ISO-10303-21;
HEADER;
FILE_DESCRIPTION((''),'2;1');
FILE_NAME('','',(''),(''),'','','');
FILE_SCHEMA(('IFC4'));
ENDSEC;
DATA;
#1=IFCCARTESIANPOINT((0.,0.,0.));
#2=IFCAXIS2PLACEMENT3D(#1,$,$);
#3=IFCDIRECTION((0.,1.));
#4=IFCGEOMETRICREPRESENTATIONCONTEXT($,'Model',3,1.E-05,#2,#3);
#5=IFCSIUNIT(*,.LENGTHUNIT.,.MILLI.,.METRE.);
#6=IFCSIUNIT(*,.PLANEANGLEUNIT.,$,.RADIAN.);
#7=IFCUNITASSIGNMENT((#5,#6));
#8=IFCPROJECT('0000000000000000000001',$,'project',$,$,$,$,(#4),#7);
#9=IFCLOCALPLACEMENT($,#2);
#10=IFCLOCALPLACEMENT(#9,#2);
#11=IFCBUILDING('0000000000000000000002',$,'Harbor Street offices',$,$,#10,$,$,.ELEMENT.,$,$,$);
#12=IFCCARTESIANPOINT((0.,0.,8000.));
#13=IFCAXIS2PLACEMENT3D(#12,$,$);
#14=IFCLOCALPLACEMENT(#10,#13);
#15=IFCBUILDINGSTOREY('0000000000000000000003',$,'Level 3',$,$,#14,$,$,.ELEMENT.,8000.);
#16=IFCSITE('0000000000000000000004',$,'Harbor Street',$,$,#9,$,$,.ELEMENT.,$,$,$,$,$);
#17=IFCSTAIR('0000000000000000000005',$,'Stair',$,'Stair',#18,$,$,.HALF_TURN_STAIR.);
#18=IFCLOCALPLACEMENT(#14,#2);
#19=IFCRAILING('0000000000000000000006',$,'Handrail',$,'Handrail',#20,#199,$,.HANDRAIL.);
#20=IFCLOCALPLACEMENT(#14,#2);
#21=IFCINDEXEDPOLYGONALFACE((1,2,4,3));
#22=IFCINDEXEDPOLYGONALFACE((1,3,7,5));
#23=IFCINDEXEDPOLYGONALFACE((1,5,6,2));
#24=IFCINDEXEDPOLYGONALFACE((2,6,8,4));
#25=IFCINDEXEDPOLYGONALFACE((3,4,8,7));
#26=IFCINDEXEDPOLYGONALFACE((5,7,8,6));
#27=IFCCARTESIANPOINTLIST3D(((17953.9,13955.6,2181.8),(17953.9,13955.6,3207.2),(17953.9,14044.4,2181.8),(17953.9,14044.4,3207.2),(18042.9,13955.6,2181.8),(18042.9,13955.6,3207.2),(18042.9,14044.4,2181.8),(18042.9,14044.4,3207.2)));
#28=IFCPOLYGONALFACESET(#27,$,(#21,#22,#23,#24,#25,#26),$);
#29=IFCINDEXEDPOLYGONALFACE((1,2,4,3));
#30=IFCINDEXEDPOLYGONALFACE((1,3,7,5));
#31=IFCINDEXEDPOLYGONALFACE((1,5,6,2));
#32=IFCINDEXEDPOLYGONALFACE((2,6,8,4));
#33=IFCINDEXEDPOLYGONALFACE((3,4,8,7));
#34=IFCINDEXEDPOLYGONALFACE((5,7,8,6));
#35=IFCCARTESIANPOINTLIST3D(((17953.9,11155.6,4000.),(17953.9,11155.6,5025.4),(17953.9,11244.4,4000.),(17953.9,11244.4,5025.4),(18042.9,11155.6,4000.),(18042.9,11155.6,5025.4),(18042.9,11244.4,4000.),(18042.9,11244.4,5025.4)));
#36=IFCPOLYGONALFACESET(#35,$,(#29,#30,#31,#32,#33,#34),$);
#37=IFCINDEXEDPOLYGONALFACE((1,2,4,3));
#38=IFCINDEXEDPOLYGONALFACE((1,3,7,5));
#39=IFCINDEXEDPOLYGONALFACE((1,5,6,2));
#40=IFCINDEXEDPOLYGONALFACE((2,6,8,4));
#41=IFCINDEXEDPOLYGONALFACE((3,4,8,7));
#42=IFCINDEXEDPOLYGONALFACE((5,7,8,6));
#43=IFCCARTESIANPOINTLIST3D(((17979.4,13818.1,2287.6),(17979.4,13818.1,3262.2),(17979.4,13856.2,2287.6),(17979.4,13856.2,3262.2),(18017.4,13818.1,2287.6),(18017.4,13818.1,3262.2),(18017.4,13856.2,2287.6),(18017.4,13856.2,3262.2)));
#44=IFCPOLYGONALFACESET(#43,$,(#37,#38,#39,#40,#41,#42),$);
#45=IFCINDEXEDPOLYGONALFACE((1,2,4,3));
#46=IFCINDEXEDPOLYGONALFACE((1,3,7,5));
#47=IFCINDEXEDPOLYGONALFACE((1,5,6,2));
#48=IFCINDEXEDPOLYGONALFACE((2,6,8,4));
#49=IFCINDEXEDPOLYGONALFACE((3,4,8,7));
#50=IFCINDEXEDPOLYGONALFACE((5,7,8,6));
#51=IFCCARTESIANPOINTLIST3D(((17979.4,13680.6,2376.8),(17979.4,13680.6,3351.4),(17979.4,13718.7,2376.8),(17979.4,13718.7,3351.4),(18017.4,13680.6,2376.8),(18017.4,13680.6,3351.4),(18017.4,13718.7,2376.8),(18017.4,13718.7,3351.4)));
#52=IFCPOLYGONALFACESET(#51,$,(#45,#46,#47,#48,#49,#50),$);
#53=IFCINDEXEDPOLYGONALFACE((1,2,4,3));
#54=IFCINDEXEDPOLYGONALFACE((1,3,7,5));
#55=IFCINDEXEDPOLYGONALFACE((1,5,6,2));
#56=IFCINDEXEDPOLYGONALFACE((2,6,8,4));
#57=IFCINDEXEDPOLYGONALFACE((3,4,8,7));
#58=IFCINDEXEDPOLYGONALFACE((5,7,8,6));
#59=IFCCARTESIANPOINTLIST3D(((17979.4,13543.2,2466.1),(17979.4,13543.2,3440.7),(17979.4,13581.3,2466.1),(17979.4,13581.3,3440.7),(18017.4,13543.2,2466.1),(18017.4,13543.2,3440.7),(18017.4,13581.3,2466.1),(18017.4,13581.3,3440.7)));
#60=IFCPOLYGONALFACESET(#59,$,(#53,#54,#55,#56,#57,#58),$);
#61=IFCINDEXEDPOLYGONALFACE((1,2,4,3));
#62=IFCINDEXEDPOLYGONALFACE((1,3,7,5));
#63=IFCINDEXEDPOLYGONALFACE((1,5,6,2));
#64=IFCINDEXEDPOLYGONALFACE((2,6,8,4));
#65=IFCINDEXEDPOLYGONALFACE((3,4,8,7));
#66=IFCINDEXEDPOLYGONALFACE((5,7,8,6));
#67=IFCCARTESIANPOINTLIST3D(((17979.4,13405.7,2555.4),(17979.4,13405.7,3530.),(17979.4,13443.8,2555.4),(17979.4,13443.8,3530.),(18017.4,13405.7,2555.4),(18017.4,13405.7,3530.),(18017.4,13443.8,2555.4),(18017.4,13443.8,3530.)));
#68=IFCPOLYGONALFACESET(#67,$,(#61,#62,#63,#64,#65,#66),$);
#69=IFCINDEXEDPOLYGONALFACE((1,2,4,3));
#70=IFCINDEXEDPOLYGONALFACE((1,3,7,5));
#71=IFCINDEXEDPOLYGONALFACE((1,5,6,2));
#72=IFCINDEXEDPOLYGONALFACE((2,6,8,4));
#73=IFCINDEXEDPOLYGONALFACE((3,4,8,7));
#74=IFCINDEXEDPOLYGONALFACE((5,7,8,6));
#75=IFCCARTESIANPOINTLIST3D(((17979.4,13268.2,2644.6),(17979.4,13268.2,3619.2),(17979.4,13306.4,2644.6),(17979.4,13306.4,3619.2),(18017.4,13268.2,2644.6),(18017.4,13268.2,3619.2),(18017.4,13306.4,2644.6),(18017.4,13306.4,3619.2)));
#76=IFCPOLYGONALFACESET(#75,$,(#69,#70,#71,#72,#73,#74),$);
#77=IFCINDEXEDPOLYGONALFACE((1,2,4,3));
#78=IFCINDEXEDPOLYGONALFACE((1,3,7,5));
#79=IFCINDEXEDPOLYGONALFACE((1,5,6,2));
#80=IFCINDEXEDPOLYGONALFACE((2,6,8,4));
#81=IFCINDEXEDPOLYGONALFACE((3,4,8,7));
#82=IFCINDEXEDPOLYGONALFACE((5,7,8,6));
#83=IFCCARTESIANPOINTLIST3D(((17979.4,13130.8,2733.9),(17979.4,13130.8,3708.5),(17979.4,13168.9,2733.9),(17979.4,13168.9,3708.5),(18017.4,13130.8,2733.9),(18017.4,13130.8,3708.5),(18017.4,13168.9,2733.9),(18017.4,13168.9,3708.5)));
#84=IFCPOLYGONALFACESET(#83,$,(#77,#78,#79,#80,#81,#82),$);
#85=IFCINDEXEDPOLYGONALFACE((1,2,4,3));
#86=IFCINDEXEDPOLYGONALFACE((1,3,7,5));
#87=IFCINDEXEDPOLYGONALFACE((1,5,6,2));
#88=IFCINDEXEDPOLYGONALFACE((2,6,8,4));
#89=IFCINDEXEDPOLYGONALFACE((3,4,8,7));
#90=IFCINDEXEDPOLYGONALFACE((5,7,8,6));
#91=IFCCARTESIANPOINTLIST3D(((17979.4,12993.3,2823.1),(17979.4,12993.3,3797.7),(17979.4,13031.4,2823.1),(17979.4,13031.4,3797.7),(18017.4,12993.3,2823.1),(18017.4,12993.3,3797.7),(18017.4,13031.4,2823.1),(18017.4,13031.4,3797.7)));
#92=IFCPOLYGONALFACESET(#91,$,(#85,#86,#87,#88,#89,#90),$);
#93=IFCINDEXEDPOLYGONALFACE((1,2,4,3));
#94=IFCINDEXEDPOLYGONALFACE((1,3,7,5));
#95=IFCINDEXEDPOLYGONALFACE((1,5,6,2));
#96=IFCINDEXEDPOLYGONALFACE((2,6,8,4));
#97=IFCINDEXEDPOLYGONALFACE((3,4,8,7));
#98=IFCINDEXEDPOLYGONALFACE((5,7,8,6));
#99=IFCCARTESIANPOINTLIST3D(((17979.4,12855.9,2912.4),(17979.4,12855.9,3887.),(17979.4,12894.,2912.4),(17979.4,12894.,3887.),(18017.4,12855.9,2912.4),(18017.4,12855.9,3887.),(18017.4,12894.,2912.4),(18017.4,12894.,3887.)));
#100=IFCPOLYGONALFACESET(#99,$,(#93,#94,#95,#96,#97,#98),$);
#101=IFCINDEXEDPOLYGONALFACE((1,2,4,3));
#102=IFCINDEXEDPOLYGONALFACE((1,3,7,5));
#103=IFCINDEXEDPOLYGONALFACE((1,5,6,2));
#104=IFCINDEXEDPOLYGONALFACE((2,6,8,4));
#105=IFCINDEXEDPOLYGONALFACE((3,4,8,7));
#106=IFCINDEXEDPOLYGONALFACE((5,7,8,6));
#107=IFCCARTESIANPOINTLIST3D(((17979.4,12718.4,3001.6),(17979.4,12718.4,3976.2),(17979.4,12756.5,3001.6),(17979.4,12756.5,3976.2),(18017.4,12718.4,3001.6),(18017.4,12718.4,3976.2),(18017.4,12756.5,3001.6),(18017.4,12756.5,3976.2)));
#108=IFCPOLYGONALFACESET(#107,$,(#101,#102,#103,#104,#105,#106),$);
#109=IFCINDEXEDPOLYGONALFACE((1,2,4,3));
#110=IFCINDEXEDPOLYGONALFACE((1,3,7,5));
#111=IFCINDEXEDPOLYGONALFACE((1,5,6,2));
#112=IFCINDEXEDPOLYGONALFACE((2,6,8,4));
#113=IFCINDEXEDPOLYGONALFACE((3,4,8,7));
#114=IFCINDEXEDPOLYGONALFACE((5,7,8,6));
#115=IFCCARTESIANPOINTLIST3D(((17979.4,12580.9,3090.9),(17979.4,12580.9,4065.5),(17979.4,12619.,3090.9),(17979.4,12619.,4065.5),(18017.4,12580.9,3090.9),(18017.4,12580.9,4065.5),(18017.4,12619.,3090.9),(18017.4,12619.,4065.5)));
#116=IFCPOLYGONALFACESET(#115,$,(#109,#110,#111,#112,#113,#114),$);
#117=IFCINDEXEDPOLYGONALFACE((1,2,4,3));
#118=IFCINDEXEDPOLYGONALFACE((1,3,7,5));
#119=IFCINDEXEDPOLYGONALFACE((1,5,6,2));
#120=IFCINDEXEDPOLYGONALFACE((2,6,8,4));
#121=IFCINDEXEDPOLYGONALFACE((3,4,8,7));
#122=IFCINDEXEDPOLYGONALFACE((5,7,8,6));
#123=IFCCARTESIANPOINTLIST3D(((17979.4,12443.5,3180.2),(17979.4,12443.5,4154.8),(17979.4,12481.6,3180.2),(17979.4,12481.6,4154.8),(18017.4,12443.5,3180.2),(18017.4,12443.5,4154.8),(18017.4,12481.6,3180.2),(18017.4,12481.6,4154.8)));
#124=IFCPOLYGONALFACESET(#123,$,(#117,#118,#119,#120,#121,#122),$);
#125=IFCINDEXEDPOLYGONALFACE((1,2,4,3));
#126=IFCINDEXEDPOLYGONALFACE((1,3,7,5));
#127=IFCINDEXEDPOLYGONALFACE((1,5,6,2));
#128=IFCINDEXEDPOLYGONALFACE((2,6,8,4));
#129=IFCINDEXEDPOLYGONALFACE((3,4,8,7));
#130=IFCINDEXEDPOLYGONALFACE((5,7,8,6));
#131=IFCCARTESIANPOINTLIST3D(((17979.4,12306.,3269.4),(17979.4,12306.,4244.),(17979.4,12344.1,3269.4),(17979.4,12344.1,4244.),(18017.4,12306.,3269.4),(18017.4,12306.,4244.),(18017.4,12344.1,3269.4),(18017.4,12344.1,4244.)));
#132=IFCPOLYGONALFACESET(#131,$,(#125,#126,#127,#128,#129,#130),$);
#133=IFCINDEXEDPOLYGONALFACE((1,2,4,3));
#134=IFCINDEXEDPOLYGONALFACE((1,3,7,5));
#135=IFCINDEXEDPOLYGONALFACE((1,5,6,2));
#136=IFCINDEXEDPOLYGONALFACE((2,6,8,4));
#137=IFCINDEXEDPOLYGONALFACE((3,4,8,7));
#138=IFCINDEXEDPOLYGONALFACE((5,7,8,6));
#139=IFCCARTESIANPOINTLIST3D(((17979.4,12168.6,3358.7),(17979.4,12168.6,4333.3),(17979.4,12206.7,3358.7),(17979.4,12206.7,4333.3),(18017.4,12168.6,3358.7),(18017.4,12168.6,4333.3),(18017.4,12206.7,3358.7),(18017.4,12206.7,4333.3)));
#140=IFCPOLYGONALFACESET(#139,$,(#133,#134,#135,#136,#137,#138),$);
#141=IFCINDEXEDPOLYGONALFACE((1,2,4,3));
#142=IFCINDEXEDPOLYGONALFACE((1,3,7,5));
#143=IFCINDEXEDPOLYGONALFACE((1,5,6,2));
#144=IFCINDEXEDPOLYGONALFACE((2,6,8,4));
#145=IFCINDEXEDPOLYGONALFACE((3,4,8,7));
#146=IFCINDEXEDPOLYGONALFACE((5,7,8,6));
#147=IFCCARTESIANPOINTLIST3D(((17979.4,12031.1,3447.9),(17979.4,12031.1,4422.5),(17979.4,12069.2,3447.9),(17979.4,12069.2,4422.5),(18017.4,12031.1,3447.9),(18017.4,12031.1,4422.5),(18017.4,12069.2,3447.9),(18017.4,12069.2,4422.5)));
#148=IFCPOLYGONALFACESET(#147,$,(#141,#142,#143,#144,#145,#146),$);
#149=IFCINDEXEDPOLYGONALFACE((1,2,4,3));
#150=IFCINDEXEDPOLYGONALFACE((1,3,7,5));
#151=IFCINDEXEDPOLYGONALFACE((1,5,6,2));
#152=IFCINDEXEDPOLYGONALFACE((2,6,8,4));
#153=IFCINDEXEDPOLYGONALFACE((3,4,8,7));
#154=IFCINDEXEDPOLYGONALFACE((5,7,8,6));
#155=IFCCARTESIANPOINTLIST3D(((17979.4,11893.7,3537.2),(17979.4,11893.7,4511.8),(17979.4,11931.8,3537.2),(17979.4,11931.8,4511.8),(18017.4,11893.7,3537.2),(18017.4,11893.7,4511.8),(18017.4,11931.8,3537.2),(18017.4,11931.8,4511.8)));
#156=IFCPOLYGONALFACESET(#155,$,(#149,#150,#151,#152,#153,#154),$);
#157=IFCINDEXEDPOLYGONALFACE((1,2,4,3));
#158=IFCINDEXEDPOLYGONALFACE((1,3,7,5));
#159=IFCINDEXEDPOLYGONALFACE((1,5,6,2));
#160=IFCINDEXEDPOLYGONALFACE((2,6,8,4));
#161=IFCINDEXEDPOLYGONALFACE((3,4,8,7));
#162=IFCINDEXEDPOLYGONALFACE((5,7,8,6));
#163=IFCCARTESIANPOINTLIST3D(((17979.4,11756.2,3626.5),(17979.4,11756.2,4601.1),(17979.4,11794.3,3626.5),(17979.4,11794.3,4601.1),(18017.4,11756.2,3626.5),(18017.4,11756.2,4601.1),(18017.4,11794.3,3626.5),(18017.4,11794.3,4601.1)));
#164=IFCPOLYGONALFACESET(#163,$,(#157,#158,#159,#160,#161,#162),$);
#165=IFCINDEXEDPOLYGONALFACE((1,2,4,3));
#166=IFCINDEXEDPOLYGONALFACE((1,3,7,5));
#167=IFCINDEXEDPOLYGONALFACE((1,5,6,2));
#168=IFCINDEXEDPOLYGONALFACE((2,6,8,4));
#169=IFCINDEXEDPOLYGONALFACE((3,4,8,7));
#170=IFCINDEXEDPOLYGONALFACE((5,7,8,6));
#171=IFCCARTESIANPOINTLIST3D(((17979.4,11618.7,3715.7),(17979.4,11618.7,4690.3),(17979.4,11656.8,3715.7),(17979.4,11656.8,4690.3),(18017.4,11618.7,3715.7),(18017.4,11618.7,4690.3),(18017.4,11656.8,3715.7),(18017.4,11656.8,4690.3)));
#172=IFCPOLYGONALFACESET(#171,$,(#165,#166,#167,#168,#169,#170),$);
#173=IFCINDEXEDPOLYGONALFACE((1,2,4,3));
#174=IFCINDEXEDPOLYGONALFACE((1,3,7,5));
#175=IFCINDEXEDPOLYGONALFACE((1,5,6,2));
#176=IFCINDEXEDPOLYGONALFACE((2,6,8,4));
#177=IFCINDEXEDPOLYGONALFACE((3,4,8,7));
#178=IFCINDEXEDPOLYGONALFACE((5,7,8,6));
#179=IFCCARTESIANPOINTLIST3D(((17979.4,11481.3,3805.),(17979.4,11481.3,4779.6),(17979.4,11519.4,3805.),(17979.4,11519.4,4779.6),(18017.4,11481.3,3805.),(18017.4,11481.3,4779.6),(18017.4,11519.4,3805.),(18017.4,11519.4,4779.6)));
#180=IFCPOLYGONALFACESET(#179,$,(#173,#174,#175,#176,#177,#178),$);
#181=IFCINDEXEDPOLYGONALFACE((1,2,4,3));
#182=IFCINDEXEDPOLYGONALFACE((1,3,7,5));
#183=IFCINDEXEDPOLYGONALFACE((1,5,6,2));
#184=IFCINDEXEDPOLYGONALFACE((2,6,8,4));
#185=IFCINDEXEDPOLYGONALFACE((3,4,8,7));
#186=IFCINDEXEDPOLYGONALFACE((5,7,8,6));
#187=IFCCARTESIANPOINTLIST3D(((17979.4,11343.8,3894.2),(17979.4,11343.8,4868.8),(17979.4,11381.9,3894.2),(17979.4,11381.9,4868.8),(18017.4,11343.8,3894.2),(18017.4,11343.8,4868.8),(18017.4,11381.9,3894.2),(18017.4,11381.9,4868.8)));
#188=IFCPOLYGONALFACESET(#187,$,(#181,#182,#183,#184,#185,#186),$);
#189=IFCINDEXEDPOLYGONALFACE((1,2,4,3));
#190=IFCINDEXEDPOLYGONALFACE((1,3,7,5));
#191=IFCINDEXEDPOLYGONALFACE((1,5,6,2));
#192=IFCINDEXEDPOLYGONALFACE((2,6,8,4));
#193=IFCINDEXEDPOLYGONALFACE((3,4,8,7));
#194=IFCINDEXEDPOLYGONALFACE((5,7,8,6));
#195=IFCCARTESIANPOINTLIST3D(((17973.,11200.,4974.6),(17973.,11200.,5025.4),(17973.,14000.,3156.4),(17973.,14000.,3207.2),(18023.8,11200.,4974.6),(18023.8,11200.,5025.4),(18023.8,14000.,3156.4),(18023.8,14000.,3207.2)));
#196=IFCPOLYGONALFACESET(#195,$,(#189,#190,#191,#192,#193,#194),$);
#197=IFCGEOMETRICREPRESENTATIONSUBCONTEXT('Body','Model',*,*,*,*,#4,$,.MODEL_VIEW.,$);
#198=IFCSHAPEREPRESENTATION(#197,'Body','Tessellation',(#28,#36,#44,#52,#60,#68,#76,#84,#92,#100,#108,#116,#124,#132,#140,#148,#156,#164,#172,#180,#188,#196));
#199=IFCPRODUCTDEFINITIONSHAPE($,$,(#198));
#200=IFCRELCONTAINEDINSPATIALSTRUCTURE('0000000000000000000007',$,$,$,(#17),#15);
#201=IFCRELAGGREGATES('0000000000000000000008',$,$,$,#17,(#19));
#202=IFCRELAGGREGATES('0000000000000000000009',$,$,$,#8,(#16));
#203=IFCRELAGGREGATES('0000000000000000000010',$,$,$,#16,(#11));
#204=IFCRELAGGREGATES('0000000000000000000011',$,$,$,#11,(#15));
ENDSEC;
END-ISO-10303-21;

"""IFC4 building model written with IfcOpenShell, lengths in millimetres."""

from ifc_helpers import new_model, si_unit, direction, frame, origin, origin_with_axes, place, context, subcontext, project, spatial, polyline, outline, extrude, element, aggregate, save


model = new_model("IFC4")

# Units and contexts
model_context = context("Model", 3, precision=1e-05, world=origin(), true_north=direction((0.0, 1.0)))
body_context = subcontext(model_context, "Body", "Model", "MODEL_VIEW")
ifc_project = project(units=[si_unit("LENGTHUNIT", "METRE", prefix="MILLI"), si_unit("PLANEANGLEUNIT", "RADIAN")], contexts=[model_context])

# Site, building, storey
site_placement = place(None, origin())
site = spatial("IfcSite", under=ifc_project, at=site_placement, Name="Harbor Street", CompositionType="ELEMENT")
building_placement = place(site_placement, origin())
building = spatial("IfcBuilding", under=site, at=building_placement, Name="Harbor Street offices", CompositionType="ELEMENT")
storey_placement = place(building_placement, frame((0.0, 0.0, 8000.0)))
storey = spatial("IfcBuildingStorey", under=building, at=storey_placement, Name="Level 3", CompositionType="ELEMENT", Elevation=8000.0)

# Stair
stair_placement = place(storey_placement, origin_with_axes())
stair = element("IfcStair", 1, at=stair_placement, inside=storey, Name="Stair", ObjectType="Stair", PredefinedType="HALF_TURN_STAIR")

# Railing
railing_1_placement = place(storey_placement, origin_with_axes())
railing_1 = element("IfcRailing", 2, at=railing_1_placement, Name="Handrail", ObjectType="Handrail", PredefinedType="HANDRAIL", context=body_context, shape_type="SweptSolid", body=[
    extrude(outline(polyline([(-44.5, -44.5), (44.5, -44.5), (44.5, 44.5), (-44.5, 44.5), (-44.5, -44.5)])), frame((17998.4, 14000.0, 2181.8), z_axis=(0.0, 0.0, 1.0), x_axis=(1.0, 0.0, 0.0)), (0.0, 0.0, 1.0), 1025.4),
    extrude(outline(polyline([(-44.5, -44.5), (44.5, -44.5), (44.5, 44.5), (-44.5, 44.5), (-44.5, -44.5)])), frame((17998.4, 11200.0, 4000.0), z_axis=(0.0, 0.0, 1.0), x_axis=(1.0, 0.0, 0.0)), (0.0, 0.0, 1.0), 1025.4),
    extrude(outline(polyline([(-19.1, -19.1), (19.1, -19.1), (19.1, 19.1), (-19.1, 19.1), (-19.1, -19.1)])), frame((17998.4, 13837.1, 2287.6), z_axis=(0.0, 0.0, 1.0), x_axis=(1.0, 0.0, 0.0)), (0.0, 0.0, 1.0), 974.6),
    extrude(outline(polyline([(-19.1, -19.1), (19.1, -19.1), (19.1, 19.1), (-19.1, 19.1), (-19.1, -19.1)])), frame((17998.4, 13699.7, 2376.8), z_axis=(0.0, 0.0, 1.0), x_axis=(1.0, 0.0, 0.0)), (0.0, 0.0, 1.0), 974.6),
    extrude(outline(polyline([(-19.1, -19.1), (19.1, -19.1), (19.1, 19.1), (-19.1, 19.1), (-19.1, -19.1)])), frame((17998.4, 13562.2, 2466.1), z_axis=(0.0, 0.0, 1.0), x_axis=(1.0, 0.0, 0.0)), (0.0, 0.0, 1.0), 974.6),
    extrude(outline(polyline([(-19.1, -19.1), (19.1, -19.1), (19.1, 19.1), (-19.1, 19.1), (-19.1, -19.1)])), frame((17998.4, 13424.8, 2555.4), z_axis=(0.0, 0.0, 1.0), x_axis=(1.0, 0.0, 0.0)), (0.0, 0.0, 1.0), 974.6),
    extrude(outline(polyline([(-19.1, -19.1), (19.1, -19.1), (19.1, 19.1), (-19.1, 19.1), (-19.1, -19.1)])), frame((17998.4, 13287.3, 2644.6), z_axis=(0.0, 0.0, 1.0), x_axis=(1.0, 0.0, 0.0)), (0.0, 0.0, 1.0), 974.6),
    extrude(outline(polyline([(-19.1, -19.1), (19.1, -19.1), (19.1, 19.1), (-19.1, 19.1), (-19.1, -19.1)])), frame((17998.4, 13149.8, 2733.9), z_axis=(0.0, 0.0, 1.0), x_axis=(1.0, 0.0, 0.0)), (0.0, 0.0, 1.0), 974.6),
    extrude(outline(polyline([(-19.1, -19.1), (19.1, -19.1), (19.1, 19.1), (-19.1, 19.1), (-19.1, -19.1)])), frame((17998.4, 13012.4, 2823.1), z_axis=(0.0, 0.0, 1.0), x_axis=(1.0, 0.0, 0.0)), (0.0, 0.0, 1.0), 974.6),
    extrude(outline(polyline([(-19.1, -19.1), (19.1, -19.1), (19.1, 19.1), (-19.1, 19.1), (-19.1, -19.1)])), frame((17998.4, 12874.9, 2912.4), z_axis=(0.0, 0.0, 1.0), x_axis=(1.0, 0.0, 0.0)), (0.0, 0.0, 1.0), 974.6),
    extrude(outline(polyline([(-19.1, -19.1), (19.1, -19.1), (19.1, 19.1), (-19.1, 19.1), (-19.1, -19.1)])), frame((17998.4, 12737.5, 3001.6), z_axis=(0.0, 0.0, 1.0), x_axis=(1.0, 0.0, 0.0)), (0.0, 0.0, 1.0), 974.6),
    extrude(outline(polyline([(-19.1, -19.1), (19.1, -19.1), (19.1, 19.1), (-19.1, 19.1), (-19.1, -19.1)])), frame((17998.4, 12600.0, 3090.9), z_axis=(0.0, 0.0, 1.0), x_axis=(1.0, 0.0, 0.0)), (0.0, 0.0, 1.0), 974.6),
    extrude(outline(polyline([(-19.1, -19.1), (19.1, -19.1), (19.1, 19.1), (-19.1, 19.1), (-19.1, -19.1)])), frame((17998.4, 12462.5, 3180.2), z_axis=(0.0, 0.0, 1.0), x_axis=(1.0, 0.0, 0.0)), (0.0, 0.0, 1.0), 974.6),
    extrude(outline(polyline([(-19.1, -19.1), (19.1, -19.1), (19.1, 19.1), (-19.1, 19.1), (-19.1, -19.1)])), frame((17998.4, 12325.1, 3269.4), z_axis=(0.0, 0.0, 1.0), x_axis=(1.0, 0.0, 0.0)), (0.0, 0.0, 1.0), 974.6),
    extrude(outline(polyline([(-19.1, -19.1), (19.1, -19.1), (19.1, 19.1), (-19.1, 19.1), (-19.1, -19.1)])), frame((17998.4, 12187.6, 3358.7), z_axis=(0.0, 0.0, 1.0), x_axis=(1.0, 0.0, 0.0)), (0.0, 0.0, 1.0), 974.6),
    extrude(outline(polyline([(-19.1, -19.1), (19.1, -19.1), (19.1, 19.1), (-19.1, 19.1), (-19.1, -19.1)])), frame((17998.4, 12050.2, 3447.9), z_axis=(0.0, 0.0, 1.0), x_axis=(1.0, 0.0, 0.0)), (0.0, 0.0, 1.0), 974.6),
    extrude(outline(polyline([(-19.1, -19.1), (19.1, -19.1), (19.1, 19.1), (-19.1, 19.1), (-19.1, -19.1)])), frame((17998.4, 11912.7, 3537.2), z_axis=(0.0, 0.0, 1.0), x_axis=(1.0, 0.0, 0.0)), (0.0, 0.0, 1.0), 974.6),
    extrude(outline(polyline([(-19.1, -19.1), (19.1, -19.1), (19.1, 19.1), (-19.1, 19.1), (-19.1, -19.1)])), frame((17998.4, 11775.2, 3626.5), z_axis=(0.0, 0.0, 1.0), x_axis=(1.0, 0.0, 0.0)), (0.0, 0.0, 1.0), 974.6),
    extrude(outline(polyline([(-19.1, -19.1), (19.1, -19.1), (19.1, 19.1), (-19.1, 19.1), (-19.1, -19.1)])), frame((17998.4, 11637.8, 3715.7), z_axis=(0.0, 0.0, 1.0), x_axis=(1.0, 0.0, 0.0)), (0.0, 0.0, 1.0), 974.6),
    extrude(outline(polyline([(-19.1, -19.1), (19.1, -19.1), (19.1, 19.1), (-19.1, 19.1), (-19.1, -19.1)])), frame((17998.4, 11500.3, 3805.0), z_axis=(0.0, 0.0, 1.0), x_axis=(1.0, 0.0, 0.0)), (0.0, 0.0, 1.0), 974.6),
    extrude(outline(polyline([(-19.1, -19.1), (19.1, -19.1), (19.1, 19.1), (-19.1, 19.1), (-19.1, -19.1)])), frame((17998.4, 11362.9, 3894.2), z_axis=(0.0, 0.0, 1.0), x_axis=(1.0, 0.0, 0.0)), (0.0, 0.0, 1.0), 974.6),
    extrude(outline(polyline([(0.0, 0.0), (50.8, 0.0), (50.8, 50.8), (0.0, 50.8), (0.0, 0.0)])), frame((17973.0, 14000.0, 3156.4), z_axis=(0.0, -1.0, 0.0), x_axis=(1.0, 0.0, 0.0)), (0.0, 0.544605, 0.838692), 3338.5),
])
aggregate(stair, [railing_1])

save(model, "model.ifc")
